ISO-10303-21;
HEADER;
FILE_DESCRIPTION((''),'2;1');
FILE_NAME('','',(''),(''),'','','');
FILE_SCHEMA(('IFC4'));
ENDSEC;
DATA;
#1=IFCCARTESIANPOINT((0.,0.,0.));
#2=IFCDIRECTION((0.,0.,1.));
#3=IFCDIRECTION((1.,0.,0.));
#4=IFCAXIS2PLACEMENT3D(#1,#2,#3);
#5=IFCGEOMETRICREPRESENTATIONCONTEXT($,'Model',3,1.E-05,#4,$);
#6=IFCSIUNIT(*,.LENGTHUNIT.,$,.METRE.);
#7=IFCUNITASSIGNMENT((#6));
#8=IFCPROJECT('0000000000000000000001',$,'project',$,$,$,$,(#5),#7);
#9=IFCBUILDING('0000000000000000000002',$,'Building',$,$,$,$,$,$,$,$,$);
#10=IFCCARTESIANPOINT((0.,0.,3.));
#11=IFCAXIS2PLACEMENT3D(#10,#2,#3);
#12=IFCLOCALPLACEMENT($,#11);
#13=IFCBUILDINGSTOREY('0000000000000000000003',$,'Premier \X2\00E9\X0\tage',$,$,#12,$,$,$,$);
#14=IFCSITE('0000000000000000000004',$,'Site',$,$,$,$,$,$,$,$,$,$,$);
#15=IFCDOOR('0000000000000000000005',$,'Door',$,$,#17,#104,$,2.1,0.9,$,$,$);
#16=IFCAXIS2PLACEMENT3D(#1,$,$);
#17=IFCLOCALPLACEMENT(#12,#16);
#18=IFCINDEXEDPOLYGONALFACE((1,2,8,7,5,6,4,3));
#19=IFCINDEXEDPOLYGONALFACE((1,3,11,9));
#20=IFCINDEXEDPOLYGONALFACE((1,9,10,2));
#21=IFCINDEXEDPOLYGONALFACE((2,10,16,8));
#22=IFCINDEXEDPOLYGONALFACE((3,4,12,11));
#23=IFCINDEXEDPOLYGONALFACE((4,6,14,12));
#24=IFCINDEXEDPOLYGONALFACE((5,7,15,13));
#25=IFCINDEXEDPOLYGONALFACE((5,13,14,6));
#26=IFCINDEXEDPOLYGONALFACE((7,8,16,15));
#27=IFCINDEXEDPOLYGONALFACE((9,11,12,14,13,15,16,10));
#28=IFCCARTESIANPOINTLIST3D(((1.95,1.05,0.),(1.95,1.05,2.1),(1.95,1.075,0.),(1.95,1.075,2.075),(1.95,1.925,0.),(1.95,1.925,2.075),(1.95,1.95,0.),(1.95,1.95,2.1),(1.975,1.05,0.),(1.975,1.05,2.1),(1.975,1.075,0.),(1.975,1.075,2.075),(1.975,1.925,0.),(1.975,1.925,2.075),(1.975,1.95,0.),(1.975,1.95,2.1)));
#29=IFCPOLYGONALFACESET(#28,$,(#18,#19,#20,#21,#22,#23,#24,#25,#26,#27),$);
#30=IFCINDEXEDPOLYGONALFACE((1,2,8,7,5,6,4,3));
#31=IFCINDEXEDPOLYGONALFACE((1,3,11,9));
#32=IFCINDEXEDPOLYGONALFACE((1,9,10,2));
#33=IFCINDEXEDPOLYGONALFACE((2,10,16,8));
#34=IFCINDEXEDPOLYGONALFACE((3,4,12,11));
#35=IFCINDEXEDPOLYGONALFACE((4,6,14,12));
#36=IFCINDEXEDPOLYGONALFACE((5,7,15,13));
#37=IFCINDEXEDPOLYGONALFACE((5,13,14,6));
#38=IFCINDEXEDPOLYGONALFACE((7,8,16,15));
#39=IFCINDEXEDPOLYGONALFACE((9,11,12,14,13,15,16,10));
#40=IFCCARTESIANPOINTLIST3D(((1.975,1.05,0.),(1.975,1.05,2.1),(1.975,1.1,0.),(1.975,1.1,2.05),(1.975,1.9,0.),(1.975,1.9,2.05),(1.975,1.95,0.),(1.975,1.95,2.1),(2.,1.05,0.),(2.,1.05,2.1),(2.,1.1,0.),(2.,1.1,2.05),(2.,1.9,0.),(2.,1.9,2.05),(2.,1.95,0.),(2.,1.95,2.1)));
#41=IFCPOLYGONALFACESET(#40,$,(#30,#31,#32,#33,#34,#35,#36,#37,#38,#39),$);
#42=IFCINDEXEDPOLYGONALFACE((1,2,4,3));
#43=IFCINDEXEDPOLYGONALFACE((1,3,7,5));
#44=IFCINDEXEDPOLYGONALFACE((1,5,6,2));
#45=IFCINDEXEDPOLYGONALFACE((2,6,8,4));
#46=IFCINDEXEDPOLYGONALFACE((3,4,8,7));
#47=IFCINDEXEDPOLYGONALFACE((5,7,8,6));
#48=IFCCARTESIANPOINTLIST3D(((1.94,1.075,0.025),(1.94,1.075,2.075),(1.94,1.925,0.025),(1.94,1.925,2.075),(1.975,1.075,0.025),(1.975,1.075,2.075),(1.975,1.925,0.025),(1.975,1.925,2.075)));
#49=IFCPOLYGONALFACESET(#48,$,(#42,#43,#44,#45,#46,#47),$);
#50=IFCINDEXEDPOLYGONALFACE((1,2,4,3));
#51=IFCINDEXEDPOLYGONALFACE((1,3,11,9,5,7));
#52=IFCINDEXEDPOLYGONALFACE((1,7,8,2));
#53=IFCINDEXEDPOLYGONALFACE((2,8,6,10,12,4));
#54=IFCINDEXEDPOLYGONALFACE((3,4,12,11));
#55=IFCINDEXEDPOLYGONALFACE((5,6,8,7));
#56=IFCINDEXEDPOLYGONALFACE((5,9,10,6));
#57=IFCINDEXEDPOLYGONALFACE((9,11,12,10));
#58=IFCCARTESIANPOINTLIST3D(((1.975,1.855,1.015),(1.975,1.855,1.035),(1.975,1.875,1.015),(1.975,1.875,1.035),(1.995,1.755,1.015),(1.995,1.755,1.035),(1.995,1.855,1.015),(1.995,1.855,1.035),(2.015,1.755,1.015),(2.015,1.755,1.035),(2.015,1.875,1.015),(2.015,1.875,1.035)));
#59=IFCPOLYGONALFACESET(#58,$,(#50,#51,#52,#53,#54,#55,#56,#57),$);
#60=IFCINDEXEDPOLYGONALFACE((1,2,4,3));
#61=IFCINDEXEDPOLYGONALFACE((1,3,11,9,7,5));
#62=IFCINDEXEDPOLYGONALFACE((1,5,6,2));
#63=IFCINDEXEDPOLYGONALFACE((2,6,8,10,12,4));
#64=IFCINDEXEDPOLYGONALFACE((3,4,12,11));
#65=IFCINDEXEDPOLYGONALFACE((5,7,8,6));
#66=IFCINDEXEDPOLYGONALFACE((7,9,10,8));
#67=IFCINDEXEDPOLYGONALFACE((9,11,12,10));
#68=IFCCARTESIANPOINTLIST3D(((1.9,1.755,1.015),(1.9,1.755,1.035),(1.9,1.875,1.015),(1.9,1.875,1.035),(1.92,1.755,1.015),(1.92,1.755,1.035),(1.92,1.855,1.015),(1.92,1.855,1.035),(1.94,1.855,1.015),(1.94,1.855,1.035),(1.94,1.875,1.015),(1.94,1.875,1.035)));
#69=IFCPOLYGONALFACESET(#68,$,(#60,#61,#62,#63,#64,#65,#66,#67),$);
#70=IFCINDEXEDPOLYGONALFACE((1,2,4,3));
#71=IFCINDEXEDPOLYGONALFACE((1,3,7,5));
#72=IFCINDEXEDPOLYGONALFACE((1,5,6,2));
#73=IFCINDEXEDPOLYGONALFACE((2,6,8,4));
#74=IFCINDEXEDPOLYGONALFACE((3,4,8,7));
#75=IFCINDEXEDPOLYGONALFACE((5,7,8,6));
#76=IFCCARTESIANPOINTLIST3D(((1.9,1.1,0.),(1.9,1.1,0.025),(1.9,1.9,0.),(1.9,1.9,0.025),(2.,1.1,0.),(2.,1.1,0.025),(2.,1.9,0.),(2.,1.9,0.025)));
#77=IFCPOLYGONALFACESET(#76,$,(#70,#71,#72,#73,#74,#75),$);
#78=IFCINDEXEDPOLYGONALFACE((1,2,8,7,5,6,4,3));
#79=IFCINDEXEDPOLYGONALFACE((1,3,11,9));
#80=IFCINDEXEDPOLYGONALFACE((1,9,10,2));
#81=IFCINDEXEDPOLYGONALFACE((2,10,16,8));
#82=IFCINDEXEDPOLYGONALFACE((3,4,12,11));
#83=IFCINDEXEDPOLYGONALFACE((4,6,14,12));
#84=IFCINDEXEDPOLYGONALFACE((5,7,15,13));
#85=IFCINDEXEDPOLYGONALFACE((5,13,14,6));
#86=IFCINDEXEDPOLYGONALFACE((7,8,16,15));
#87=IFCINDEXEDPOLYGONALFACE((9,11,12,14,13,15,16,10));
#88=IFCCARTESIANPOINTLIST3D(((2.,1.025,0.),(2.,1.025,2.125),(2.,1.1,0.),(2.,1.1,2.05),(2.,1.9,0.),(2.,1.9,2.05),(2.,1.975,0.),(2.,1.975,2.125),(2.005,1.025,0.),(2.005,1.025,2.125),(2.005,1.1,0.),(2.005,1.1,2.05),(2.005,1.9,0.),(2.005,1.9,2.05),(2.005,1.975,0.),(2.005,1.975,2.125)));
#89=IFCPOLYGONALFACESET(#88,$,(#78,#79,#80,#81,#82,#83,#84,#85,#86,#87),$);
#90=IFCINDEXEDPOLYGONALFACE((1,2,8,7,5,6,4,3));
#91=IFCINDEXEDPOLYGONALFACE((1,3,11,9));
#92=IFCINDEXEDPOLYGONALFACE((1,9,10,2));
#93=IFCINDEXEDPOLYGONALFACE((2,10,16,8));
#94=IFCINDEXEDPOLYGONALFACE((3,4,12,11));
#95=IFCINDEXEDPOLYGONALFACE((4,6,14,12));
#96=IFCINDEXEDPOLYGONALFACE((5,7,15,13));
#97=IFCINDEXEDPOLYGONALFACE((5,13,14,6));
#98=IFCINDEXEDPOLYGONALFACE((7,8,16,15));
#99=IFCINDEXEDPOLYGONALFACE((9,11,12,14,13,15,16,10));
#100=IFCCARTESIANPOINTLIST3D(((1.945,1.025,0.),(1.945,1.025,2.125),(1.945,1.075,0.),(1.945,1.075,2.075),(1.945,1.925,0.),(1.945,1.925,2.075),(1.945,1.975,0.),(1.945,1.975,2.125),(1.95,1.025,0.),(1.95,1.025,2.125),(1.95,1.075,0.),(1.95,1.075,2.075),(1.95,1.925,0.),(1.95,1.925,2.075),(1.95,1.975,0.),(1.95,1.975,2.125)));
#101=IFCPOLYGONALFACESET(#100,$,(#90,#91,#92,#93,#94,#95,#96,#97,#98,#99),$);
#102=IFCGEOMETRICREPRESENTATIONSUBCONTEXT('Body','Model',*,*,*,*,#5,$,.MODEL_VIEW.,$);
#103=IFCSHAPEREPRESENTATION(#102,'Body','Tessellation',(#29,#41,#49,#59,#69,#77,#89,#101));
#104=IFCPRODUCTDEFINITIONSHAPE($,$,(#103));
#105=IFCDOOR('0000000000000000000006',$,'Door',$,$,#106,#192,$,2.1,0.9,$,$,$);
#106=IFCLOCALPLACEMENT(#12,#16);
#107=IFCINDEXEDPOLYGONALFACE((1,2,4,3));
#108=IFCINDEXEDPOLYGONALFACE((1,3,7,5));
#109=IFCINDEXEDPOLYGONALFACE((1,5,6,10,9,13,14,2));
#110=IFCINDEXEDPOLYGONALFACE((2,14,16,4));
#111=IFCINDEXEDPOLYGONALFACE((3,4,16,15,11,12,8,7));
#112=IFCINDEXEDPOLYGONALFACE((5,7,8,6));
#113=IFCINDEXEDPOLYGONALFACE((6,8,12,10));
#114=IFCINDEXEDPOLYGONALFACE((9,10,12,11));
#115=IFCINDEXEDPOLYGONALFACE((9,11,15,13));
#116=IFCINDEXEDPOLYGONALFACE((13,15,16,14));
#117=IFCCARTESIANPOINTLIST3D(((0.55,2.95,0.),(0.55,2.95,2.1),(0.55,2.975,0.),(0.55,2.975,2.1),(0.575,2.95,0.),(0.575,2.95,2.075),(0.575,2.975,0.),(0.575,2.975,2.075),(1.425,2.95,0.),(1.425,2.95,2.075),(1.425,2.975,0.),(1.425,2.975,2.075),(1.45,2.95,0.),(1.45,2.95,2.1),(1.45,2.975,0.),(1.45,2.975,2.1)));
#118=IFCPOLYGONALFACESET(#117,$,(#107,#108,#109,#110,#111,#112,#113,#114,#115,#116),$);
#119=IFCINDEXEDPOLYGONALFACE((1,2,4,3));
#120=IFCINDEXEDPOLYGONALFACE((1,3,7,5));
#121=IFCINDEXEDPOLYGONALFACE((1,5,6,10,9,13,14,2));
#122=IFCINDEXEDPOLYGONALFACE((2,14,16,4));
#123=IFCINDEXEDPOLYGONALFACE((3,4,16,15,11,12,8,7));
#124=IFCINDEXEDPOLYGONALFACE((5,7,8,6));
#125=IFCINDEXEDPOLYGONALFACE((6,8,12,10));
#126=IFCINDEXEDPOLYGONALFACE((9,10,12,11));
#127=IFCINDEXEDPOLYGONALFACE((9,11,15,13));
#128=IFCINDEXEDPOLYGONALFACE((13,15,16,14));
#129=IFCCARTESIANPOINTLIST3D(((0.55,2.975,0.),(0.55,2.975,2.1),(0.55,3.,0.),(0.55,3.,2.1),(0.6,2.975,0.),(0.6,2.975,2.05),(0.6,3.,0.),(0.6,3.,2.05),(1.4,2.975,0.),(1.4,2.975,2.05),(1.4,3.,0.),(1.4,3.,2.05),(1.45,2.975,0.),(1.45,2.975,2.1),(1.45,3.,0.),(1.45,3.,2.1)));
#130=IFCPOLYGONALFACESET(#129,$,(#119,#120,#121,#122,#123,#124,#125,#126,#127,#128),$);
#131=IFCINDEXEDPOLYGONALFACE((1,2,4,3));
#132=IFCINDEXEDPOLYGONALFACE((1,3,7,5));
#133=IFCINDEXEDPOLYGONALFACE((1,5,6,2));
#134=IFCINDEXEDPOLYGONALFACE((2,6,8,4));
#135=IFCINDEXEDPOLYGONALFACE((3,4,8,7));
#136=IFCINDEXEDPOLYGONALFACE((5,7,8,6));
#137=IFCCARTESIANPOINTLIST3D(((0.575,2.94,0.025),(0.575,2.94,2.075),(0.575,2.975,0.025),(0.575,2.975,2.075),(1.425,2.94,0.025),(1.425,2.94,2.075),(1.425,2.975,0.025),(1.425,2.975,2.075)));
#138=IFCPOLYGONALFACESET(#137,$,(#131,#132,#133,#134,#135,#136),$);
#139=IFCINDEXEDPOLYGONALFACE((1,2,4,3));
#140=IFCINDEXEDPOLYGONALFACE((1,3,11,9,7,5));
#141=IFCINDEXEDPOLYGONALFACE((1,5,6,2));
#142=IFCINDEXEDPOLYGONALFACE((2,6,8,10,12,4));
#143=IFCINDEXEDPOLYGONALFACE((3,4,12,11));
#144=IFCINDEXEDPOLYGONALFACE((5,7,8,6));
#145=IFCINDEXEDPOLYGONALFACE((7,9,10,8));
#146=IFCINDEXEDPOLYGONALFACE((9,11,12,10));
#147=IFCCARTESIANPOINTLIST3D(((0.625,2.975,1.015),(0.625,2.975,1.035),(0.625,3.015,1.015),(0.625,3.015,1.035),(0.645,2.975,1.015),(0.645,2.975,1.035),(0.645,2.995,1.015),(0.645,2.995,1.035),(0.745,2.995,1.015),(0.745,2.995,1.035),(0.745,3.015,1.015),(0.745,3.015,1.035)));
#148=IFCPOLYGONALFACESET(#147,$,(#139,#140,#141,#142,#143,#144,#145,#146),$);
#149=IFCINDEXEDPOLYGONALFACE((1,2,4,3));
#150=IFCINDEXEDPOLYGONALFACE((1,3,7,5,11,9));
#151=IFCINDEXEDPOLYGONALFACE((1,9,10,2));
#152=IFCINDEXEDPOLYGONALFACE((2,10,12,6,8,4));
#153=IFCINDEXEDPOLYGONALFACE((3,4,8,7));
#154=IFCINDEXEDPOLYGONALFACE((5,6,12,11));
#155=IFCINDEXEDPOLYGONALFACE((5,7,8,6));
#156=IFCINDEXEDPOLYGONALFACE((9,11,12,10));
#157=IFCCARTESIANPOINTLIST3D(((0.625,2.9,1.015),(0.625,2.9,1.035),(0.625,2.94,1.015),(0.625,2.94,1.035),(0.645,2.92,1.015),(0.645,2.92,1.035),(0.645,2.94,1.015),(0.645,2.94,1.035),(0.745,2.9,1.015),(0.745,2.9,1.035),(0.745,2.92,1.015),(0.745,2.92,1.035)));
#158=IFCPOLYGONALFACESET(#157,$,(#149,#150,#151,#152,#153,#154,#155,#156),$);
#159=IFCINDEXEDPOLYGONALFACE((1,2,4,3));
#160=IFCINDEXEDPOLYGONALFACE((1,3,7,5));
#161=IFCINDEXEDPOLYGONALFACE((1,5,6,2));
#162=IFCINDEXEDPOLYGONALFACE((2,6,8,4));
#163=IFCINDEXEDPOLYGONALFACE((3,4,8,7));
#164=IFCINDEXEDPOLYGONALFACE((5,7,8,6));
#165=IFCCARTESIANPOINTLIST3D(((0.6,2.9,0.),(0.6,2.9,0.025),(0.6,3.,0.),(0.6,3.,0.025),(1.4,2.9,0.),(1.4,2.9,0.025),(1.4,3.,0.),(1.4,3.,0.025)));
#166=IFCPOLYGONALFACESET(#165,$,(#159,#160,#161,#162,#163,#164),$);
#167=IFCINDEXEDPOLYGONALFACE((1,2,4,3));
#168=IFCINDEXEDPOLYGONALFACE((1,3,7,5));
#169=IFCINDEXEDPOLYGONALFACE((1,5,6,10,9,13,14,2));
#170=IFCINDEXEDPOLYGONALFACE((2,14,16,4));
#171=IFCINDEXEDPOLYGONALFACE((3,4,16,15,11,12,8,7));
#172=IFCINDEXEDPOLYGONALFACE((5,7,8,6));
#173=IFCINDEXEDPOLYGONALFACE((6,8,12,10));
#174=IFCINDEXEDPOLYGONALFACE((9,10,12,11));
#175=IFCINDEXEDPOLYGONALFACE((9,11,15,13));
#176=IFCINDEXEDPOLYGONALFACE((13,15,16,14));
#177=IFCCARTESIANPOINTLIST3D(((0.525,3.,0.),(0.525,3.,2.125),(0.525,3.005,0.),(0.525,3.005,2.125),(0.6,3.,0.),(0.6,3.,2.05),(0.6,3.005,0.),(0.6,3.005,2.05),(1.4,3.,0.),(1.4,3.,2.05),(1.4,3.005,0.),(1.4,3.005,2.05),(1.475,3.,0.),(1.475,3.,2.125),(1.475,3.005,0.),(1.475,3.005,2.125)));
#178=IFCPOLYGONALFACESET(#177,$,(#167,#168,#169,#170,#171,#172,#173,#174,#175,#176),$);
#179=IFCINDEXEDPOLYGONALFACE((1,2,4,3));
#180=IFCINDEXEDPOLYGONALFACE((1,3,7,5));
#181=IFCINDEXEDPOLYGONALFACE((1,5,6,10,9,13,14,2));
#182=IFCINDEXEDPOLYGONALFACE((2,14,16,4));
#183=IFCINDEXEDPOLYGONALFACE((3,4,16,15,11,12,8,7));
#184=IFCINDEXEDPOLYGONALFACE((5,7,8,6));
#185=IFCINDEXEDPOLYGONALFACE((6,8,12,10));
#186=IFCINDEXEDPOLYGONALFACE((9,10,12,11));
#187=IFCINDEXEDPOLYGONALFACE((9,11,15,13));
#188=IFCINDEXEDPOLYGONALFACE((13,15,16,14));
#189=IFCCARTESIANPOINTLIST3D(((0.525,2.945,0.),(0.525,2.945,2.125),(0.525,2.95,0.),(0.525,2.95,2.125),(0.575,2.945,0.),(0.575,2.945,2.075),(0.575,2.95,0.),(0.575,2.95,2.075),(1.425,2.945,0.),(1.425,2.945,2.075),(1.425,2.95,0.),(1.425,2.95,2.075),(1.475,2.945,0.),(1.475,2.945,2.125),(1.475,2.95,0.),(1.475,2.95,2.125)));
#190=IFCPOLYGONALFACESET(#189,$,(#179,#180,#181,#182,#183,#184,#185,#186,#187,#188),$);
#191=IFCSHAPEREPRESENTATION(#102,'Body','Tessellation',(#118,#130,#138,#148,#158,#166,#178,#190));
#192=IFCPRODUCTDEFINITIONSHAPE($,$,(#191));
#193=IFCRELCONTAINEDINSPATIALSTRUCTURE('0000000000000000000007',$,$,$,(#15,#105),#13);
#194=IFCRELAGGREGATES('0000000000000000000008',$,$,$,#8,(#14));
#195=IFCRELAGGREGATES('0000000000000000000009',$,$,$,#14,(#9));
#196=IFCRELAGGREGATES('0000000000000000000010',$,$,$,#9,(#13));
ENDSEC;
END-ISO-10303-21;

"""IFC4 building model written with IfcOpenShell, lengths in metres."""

from ifc_helpers import new_model, si_unit, frame, origin_with_axes, place, context, subcontext, project, spatial, line, indexed_curve, outline, extrude, element, save


model = new_model("IFC4")

# Units and contexts
model_context = context("Model", 3, precision=1e-05, world=origin_with_axes())
body_context = subcontext(model_context, "Body", "Model", "MODEL_VIEW")
ifc_project = project(units=[si_unit("LENGTHUNIT", "METRE")], contexts=[model_context])

# Site, building, storey
site = spatial("IfcSite", under=ifc_project, Name="Site")
building = spatial("IfcBuilding", under=site, Name="Building")
storey_placement = place(None, frame((0.0, 0.0, 3.0), z_axis=(0.0, 0.0, 1.0), x_axis=(1.0, 0.0, 0.0)))
storey = spatial("IfcBuildingStorey", under=building, at=storey_placement, Name="Premier étage")

# Doors
door_1_placement = place(storey_placement, frame((2.0, 1.05, 0.0), z_axis=(0.0, 0.0, 1.0), x_axis=(0.0, 1.0, 0.0)))
element("IfcDoor", 1, at=door_1_placement, inside=storey, Name="Door", OverallHeight=2.1, OverallWidth=0.9, context=body_context, shape_type="SweptSolid", body=[
    extrude(outline(indexed_curve([(0.0, 0.0), (0.0, 2.1), (0.9, 2.1), (0.9, 0.0), (0.875, 0.0), (0.875, 2.075), (0.025, 2.075), (0.025, 0.0)], segments=[line(1, 2, 3, 4, 5, 6, 7, 8, 1)])), frame((0.0, 0.025, 0.0), z_axis=(0.0, -1.0, 0.0), x_axis=(1.0, 0.0, 0.0)), (0.0, 0.0, -1.0), 0.025),
    extrude(outline(indexed_curve([(0.0, 0.0), (0.0, 2.1), (0.9, 2.1), (0.9, 0.0), (0.85, 0.0), (0.85, 2.05), (0.05, 2.05), (0.05, 0.0)], segments=[line(1, 2, 3, 4, 5, 6, 7, 8, 1)])), frame((0.0, 0.0, 0.0), z_axis=(0.0, -1.0, 0.0), x_axis=(1.0, 0.0, 0.0)), (0.0, 0.0, -1.0), 0.025),
    extrude(outline(indexed_curve([(0.0, 0.0), (0.85, 0.0), (0.85, 0.035), (0.0, 0.035)], segments=[line(1, 2, 3, 4, 1)])), frame((0.025, 0.025, 0.025), z_axis=(0.0, 0.0, 1.0), x_axis=(1.0, 0.0, 0.0)), (0.0, 0.0, 1.0), 2.05),
    extrude(outline(indexed_curve([(0.0, 0.0), (0.0, -0.04), (-0.12, -0.04), (-0.12, -0.02), (-0.02, -0.02), (-0.02, 0.0)], segments=[line(1, 2, 3, 4, 5, 6, 1)])), frame((0.825, 0.025, 1.015), z_axis=(0.0, 0.0, 1.0), x_axis=(1.0, 0.0, 0.0)), (0.0, 0.0, 1.0), 0.02),
    extrude(outline(indexed_curve([(0.0, 0.0), (0.0, 0.04), (-0.12, 0.04), (-0.12, 0.02), (-0.02, 0.02), (-0.02, 0.0)], segments=[line(1, 2, 3, 4, 5, 6, 1)])), frame((0.825, 0.06, 1.015), z_axis=(0.0, 0.0, 1.0), x_axis=(1.0, 0.0, 0.0)), (0.0, 0.0, 1.0), 0.02),
    extrude(outline(indexed_curve([(0.0, 0.0), (0.8, 0.0), (0.8, 0.1), (0.0, 0.1)], segments=[line(1, 2, 3, 4, 1)])), frame((0.05, 0.0, 0.0), z_axis=(0.0, 0.0, 1.0), x_axis=(1.0, 0.0, 0.0)), (0.0, 0.0, 1.0), 0.025),
    extrude(outline(indexed_curve([(0.0, 0.0), (0.0, 2.125), (0.95, 2.125), (0.95, 0.0), (0.875, 0.0), (0.875, 2.05), (0.075, 2.05), (0.075, 0.0)], segments=[line(1, 2, 3, 4, 5, 6, 7, 8, 1)])), frame((-0.025, -0.005, 0.0), z_axis=(0.0, -1.0, 0.0), x_axis=(1.0, 0.0, 0.0)), (0.0, 0.0, -1.0), 0.005),
    extrude(outline(indexed_curve([(0.0, 0.0), (0.0, 2.125), (0.95, 2.125), (0.95, 0.0), (0.9, 0.0), (0.9, 2.075), (0.05, 2.075), (0.05, 0.0)], segments=[line(1, 2, 3, 4, 5, 6, 7, 8, 1)])), frame((-0.025, 0.05, 0.0), z_axis=(0.0, -1.0, 0.0), x_axis=(1.0, 0.0, 0.0)), (0.0, 0.0, -1.0), 0.005),
])
door_2_placement = place(storey_placement, frame((1.45, 3.0, 0.0), z_axis=(0.0, 0.0, 1.0), x_axis=(-1.0, 0.0, 0.0)))
element("IfcDoor", 2, at=door_2_placement, inside=storey, Name="Door", OverallHeight=2.1, OverallWidth=0.9, context=body_context, shape_type="SweptSolid", body=[
    extrude(outline(indexed_curve([(0.0, 0.0), (0.0, 2.1), (0.9, 2.1), (0.9, 0.0), (0.875, 0.0), (0.875, 2.075), (0.025, 2.075), (0.025, 0.0)], segments=[line(1, 2, 3, 4, 5, 6, 7, 8, 1)])), frame((0.0, 0.025, 0.0), z_axis=(0.0, -1.0, 0.0), x_axis=(1.0, 0.0, 0.0)), (0.0, 0.0, -1.0), 0.025),
    extrude(outline(indexed_curve([(0.0, 0.0), (0.0, 2.1), (0.9, 2.1), (0.9, 0.0), (0.85, 0.0), (0.85, 2.05), (0.05, 2.05), (0.05, 0.0)], segments=[line(1, 2, 3, 4, 5, 6, 7, 8, 1)])), frame((0.0, 0.0, 0.0), z_axis=(0.0, -1.0, 0.0), x_axis=(1.0, 0.0, 0.0)), (0.0, 0.0, -1.0), 0.025),
    extrude(outline(indexed_curve([(0.0, 0.0), (0.85, 0.0), (0.85, 0.035), (0.0, 0.035)], segments=[line(1, 2, 3, 4, 1)])), frame((0.025, 0.025, 0.025), z_axis=(0.0, 0.0, 1.0), x_axis=(1.0, 0.0, 0.0)), (0.0, 0.0, 1.0), 2.05),
    extrude(outline(indexed_curve([(0.0, 0.0), (0.0, -0.04), (-0.12, -0.04), (-0.12, -0.02), (-0.02, -0.02), (-0.02, 0.0)], segments=[line(1, 2, 3, 4, 5, 6, 1)])), frame((0.825, 0.025, 1.015), z_axis=(0.0, 0.0, 1.0), x_axis=(1.0, 0.0, 0.0)), (0.0, 0.0, 1.0), 0.02),
    extrude(outline(indexed_curve([(0.0, 0.0), (0.0, 0.04), (-0.12, 0.04), (-0.12, 0.02), (-0.02, 0.02), (-0.02, 0.0)], segments=[line(1, 2, 3, 4, 5, 6, 1)])), frame((0.825, 0.06, 1.015), z_axis=(0.0, 0.0, 1.0), x_axis=(1.0, 0.0, 0.0)), (0.0, 0.0, 1.0), 0.02),
    extrude(outline(indexed_curve([(0.0, 0.0), (0.8, 0.0), (0.8, 0.1), (0.0, 0.1)], segments=[line(1, 2, 3, 4, 1)])), frame((0.05, 0.0, 0.0), z_axis=(0.0, 0.0, 1.0), x_axis=(1.0, 0.0, 0.0)), (0.0, 0.0, 1.0), 0.025),
    extrude(outline(indexed_curve([(0.0, 0.0), (0.0, 2.125), (0.95, 2.125), (0.95, 0.0), (0.875, 0.0), (0.875, 2.05), (0.075, 2.05), (0.075, 0.0)], segments=[line(1, 2, 3, 4, 5, 6, 7, 8, 1)])), frame((-0.025, -0.005, 0.0), z_axis=(0.0, -1.0, 0.0), x_axis=(1.0, 0.0, 0.0)), (0.0, 0.0, -1.0), 0.005),
    extrude(outline(indexed_curve([(0.0, 0.0), (0.0, 2.125), (0.95, 2.125), (0.95, 0.0), (0.9, 0.0), (0.9, 2.075), (0.05, 2.075), (0.05, 0.0)], segments=[line(1, 2, 3, 4, 5, 6, 7, 8, 1)])), frame((-0.025, 0.05, 0.0), z_axis=(0.0, -1.0, 0.0), x_axis=(1.0, 0.0, 0.0)), (0.0, 0.0, -1.0), 0.005),
])

save(model, "model.ifc")
